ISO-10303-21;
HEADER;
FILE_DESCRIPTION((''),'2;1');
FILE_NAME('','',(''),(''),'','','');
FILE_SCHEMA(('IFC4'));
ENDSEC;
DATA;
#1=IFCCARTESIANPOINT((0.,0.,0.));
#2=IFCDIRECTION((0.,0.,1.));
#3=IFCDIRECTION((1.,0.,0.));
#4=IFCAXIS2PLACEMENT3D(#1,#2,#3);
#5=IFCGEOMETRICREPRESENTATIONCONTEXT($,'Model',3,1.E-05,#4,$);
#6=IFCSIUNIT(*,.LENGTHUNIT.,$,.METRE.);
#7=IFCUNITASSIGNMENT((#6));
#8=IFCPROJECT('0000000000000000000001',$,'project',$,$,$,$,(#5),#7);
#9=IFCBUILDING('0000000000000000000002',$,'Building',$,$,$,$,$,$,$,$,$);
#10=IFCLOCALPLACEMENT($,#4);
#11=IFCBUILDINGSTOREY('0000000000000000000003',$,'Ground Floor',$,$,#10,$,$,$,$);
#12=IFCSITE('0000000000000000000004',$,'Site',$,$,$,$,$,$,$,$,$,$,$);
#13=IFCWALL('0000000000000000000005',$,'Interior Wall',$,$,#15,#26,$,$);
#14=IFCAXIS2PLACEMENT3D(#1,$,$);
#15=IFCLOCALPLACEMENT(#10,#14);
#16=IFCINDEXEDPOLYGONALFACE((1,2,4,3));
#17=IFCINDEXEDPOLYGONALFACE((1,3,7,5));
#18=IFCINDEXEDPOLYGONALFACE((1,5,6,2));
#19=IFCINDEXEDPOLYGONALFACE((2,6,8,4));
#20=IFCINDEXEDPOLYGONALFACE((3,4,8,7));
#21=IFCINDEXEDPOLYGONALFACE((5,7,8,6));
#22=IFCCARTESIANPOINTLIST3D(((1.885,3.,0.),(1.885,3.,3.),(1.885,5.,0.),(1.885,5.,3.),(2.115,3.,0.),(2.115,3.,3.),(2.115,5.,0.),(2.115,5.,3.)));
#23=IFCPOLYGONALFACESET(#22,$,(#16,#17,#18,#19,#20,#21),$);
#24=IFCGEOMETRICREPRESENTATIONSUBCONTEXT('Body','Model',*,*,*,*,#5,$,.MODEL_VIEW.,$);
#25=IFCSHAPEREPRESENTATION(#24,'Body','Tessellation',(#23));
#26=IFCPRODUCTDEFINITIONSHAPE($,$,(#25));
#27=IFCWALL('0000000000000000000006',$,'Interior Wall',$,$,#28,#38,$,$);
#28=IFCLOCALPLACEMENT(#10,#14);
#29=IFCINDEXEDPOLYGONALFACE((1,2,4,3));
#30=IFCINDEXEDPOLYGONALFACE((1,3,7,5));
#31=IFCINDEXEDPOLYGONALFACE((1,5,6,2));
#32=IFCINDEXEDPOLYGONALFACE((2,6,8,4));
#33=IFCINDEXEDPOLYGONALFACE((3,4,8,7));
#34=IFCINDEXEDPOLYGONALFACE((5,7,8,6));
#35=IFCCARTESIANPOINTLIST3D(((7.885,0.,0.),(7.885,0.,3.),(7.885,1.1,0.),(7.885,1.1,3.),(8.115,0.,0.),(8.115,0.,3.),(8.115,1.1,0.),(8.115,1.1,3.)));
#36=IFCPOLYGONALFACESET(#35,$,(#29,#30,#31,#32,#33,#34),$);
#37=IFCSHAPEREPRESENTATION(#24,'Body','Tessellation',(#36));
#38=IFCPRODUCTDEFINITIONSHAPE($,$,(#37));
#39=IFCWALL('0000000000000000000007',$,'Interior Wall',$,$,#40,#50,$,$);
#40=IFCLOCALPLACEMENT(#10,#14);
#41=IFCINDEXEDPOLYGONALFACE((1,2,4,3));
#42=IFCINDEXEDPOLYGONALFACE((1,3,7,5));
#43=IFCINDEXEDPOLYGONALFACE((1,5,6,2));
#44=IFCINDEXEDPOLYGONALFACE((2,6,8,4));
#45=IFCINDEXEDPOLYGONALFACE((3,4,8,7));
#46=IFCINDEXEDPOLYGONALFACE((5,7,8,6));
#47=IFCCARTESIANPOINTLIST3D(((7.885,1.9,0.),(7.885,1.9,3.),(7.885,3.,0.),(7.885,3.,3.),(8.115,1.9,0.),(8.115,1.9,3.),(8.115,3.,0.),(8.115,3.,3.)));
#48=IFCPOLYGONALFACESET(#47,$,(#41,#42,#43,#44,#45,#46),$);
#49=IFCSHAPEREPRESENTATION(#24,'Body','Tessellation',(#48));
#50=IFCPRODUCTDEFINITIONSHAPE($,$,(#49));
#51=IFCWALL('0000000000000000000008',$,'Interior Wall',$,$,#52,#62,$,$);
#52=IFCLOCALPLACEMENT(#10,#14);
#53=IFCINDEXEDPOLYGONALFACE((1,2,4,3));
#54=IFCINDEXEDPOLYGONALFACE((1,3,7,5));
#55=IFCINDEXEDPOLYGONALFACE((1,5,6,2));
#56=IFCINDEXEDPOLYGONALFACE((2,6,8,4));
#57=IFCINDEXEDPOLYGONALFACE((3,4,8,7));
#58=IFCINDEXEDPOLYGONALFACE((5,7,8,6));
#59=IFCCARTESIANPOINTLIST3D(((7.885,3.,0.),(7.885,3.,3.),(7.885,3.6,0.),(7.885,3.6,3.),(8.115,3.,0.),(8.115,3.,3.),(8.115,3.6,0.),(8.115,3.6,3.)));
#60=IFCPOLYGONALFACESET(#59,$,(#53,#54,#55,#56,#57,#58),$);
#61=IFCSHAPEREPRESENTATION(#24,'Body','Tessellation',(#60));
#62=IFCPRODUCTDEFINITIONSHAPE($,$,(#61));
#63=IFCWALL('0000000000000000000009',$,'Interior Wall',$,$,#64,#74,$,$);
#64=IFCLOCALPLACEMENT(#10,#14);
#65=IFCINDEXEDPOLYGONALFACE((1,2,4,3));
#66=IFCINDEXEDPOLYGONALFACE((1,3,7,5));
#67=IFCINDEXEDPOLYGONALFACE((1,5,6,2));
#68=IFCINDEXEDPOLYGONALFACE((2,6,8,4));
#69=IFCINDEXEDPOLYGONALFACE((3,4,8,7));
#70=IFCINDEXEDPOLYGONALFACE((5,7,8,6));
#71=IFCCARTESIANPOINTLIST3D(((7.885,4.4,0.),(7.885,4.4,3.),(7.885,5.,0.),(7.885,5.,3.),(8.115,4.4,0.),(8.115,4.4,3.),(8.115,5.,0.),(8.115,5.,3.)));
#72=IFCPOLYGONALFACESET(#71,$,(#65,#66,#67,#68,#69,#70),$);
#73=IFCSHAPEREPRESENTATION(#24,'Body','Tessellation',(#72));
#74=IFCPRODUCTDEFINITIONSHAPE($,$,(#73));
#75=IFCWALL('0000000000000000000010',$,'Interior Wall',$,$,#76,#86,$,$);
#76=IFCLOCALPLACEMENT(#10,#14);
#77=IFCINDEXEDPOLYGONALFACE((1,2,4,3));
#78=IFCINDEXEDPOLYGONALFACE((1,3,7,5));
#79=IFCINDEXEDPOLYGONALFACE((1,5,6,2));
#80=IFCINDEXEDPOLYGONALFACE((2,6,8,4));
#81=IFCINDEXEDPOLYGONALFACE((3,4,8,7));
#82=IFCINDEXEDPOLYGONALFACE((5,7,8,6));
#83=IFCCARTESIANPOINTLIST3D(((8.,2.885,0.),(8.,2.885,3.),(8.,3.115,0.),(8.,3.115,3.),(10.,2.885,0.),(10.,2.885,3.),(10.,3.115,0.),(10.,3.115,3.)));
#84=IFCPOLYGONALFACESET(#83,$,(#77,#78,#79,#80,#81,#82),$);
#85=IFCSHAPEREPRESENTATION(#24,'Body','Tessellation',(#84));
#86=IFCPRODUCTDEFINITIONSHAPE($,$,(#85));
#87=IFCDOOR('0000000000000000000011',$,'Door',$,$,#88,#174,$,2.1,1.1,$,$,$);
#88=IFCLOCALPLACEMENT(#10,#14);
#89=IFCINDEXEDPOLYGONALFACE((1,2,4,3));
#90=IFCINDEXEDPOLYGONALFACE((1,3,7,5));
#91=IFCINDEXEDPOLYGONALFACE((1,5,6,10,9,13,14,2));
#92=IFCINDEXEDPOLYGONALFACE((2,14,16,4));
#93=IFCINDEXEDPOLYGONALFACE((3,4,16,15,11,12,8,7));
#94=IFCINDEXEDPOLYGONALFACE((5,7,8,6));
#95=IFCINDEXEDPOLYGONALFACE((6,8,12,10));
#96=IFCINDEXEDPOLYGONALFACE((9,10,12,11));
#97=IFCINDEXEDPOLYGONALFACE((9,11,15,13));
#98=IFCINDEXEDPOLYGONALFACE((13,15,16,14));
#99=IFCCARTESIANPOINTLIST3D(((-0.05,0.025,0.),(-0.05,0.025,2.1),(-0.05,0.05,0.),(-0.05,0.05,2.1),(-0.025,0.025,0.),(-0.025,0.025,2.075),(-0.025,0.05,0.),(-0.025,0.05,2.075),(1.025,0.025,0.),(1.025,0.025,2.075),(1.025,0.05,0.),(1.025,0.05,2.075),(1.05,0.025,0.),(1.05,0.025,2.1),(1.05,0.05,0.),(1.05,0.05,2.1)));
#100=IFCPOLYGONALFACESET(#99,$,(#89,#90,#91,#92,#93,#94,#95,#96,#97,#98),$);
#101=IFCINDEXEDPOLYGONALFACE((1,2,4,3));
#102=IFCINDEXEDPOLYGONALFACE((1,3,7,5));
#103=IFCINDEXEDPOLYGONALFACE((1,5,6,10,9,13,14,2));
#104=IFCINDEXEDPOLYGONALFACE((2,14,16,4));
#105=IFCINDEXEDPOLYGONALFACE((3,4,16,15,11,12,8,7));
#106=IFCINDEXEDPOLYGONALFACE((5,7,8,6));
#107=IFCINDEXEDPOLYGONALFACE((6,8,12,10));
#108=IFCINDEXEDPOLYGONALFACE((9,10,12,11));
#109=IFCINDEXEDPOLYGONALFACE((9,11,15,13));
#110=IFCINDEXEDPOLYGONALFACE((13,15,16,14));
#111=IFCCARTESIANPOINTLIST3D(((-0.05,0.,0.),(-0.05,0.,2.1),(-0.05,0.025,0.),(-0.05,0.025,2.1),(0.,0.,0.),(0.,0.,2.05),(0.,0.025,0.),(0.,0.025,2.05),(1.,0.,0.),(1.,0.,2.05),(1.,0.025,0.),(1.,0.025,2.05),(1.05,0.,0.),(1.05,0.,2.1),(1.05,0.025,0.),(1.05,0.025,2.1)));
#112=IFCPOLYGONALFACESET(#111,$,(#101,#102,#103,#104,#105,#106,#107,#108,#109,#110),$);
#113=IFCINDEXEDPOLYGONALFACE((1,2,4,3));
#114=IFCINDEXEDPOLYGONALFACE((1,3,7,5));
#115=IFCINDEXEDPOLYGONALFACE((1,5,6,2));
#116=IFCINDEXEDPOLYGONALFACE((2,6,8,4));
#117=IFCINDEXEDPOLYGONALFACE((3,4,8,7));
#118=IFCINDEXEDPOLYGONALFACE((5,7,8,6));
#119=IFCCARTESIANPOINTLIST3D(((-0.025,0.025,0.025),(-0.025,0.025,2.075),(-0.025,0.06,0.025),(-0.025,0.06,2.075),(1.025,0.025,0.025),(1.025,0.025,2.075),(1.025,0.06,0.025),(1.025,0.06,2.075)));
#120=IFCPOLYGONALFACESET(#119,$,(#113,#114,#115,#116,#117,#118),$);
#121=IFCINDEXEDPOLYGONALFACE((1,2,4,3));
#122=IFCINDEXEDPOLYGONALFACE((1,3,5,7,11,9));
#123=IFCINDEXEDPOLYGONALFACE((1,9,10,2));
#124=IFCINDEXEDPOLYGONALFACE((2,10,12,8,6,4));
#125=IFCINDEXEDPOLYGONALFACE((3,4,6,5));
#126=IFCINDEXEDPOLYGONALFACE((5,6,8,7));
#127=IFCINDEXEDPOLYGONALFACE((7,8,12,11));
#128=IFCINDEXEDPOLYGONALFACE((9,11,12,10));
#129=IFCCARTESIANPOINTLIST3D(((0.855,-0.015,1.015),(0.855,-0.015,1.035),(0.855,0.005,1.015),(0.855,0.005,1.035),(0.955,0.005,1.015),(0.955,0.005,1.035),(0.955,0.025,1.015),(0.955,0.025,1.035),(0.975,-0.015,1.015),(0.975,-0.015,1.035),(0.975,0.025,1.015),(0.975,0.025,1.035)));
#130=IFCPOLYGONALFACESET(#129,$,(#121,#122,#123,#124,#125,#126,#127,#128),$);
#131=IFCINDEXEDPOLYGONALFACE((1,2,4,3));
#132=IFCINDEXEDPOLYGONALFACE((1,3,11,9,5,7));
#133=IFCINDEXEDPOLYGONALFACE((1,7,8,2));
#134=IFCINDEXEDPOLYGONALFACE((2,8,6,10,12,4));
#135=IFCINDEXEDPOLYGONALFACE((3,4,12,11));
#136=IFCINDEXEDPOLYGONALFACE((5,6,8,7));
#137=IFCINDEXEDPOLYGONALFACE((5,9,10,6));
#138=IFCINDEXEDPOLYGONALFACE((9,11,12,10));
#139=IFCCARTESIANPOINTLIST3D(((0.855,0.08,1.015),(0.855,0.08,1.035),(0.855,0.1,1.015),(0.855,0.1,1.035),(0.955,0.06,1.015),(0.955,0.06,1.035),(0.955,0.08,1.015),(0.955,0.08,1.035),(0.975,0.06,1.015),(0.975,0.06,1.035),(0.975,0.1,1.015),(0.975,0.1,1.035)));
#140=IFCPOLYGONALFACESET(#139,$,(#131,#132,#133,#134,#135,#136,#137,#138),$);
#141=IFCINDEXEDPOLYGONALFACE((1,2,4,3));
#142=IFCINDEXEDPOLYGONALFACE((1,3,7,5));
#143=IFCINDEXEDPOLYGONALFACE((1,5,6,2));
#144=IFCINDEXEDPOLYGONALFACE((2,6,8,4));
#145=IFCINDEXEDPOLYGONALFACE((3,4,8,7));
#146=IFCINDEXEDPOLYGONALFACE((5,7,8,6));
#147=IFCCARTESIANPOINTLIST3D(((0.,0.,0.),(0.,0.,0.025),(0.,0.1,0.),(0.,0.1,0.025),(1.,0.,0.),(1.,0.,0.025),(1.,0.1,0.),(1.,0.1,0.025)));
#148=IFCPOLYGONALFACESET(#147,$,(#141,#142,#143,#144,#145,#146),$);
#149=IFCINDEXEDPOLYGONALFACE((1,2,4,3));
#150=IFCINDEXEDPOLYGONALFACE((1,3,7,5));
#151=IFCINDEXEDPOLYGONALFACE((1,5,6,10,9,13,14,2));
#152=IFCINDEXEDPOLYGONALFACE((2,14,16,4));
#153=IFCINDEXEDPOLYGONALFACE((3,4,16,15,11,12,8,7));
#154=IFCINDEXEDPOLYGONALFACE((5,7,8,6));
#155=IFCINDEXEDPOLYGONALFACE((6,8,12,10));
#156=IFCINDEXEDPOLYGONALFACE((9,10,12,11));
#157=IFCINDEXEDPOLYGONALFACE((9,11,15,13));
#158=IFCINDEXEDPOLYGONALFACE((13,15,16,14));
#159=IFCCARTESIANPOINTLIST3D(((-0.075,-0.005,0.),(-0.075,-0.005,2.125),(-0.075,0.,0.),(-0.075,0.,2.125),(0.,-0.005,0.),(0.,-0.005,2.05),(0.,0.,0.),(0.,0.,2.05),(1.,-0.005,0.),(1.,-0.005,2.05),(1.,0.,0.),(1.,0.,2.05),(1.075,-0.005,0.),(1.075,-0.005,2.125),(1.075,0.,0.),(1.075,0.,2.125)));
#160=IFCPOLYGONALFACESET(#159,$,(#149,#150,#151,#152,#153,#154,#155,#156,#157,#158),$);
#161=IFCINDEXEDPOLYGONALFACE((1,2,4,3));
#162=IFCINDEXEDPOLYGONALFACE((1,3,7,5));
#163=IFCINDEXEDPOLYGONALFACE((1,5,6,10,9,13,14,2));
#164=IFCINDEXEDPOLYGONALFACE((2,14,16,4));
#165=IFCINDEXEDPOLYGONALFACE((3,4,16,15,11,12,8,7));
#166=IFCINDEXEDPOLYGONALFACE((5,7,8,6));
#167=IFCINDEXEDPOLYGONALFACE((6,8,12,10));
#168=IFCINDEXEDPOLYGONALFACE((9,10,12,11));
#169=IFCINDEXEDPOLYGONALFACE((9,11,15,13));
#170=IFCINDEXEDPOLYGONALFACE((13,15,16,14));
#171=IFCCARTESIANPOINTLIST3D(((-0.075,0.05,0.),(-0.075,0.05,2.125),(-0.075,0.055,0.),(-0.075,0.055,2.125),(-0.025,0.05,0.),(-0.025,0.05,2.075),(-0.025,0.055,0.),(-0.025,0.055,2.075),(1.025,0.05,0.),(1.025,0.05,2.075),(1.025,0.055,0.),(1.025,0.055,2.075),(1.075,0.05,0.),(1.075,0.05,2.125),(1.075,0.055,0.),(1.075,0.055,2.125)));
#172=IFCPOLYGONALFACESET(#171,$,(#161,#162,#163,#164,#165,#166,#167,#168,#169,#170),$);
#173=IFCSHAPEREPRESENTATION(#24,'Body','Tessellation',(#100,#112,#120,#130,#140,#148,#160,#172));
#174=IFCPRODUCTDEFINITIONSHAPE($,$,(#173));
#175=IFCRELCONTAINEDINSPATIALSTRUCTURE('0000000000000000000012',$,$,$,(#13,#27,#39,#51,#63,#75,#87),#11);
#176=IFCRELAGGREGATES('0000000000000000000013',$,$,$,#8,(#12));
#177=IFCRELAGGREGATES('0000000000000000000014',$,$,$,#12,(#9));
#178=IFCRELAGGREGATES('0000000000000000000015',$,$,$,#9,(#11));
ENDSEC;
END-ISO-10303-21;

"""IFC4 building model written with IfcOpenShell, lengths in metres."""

from ifc_helpers import new_model, si_unit, frame, origin_with_axes, place, context, subcontext, project, spatial, line, indexed_curve, outline, extrude, element, save


model = new_model("IFC4")

# Units and contexts
model_context = context("Model", 3, precision=1e-05, world=origin_with_axes())
body_context = subcontext(model_context, "Body", "Model", "MODEL_VIEW")
ifc_project = project(units=[si_unit("LENGTHUNIT", "METRE")], contexts=[model_context])

# Site, building, storey
site = spatial("IfcSite", under=ifc_project, Name="Site")
building = spatial("IfcBuilding", under=site, Name="Building")
storey_placement = place(None, origin_with_axes())
storey = spatial("IfcBuildingStorey", under=building, at=storey_placement, Name="Ground Floor")

# Walls
wall_1_placement = place(storey_placement, frame((2.0, 5.0, 0.0), z_axis=(0.0, 0.0, 1.0), x_axis=(0.0, -1.0, 0.0)))
element("IfcWall", 1, at=wall_1_placement, inside=storey, Name="Interior Wall", context=body_context, shape_type="SweptSolid", body=[
    extrude(outline(indexed_curve([(0.0, 0.0), (0.0, 0.23), (2.0, 0.23), (2.0, 0.0), (0.0, 0.0)], self_intersect=False)), frame((0.0, -0.115, 0.0), z_axis=(0.0, 0.0, 1.0), x_axis=(1.0, 0.0, 0.0)), (0.0, 0.0, 1.0), 3.0),
])
for number, where, z_axis, x_axis, name in (
    (2, (8.0, 0.0, 0.0), (0.0, 0.0, 1.0), (0.0, 1.0, 0.0), "Interior Wall"),
    (3, (8.0, 1.9, 0.0), (0.0, 0.0, 1.0), (0.0, 1.0, 0.0), "Interior Wall"),
):
    element("IfcWall", number, at=place(storey_placement, frame(where, z_axis=z_axis, x_axis=x_axis)), inside=storey, Name=name, context=body_context, shape_type="SweptSolid", body=[
        extrude(outline(indexed_curve([(0.0, 0.0), (0.0, 0.23), (1.1, 0.23), (1.1, 0.0), (0.0, 0.0)], self_intersect=False)), frame((0.0, -0.115, 0.0), z_axis=(0.0, 0.0, 1.0), x_axis=(1.0, 0.0, 0.0)), (0.0, 0.0, 1.0), 3.0),
    ])
wall_2_placement = place(storey_placement, frame((8.0, 3.0, 0.0), z_axis=(0.0, 0.0, 1.0), x_axis=(0.0, 1.0, 0.0)))
element("IfcWall", 4, at=wall_2_placement, inside=storey, Name="Interior Wall", context=body_context, shape_type="SweptSolid", body=[
    extrude(outline(indexed_curve([(0.0, 0.0), (0.0, 0.23), (0.6, 0.23), (0.6, 0.0), (0.0, 0.0)], self_intersect=False)), frame((0.0, -0.115, 0.0), z_axis=(0.0, 0.0, 1.0), x_axis=(1.0, 0.0, 0.0)), (0.0, 0.0, 1.0), 3.0),
])
wall_3_placement = place(storey_placement, frame((8.0, 4.4, 0.0), z_axis=(0.0, 0.0, 1.0), x_axis=(0.0, 1.0, 0.0)))
element("IfcWall", 5, at=wall_3_placement, inside=storey, Name="Interior Wall", context=body_context, shape_type="SweptSolid", body=[
    extrude(outline(indexed_curve([(0.0, 0.0), (0.0, 0.23), (0.6, 0.23), (0.6, 0.0), (0.0, 0.0)], self_intersect=False)), frame((0.0, -0.115, 0.0), z_axis=(0.0, 0.0, 1.0), x_axis=(1.0, 0.0, 0.0)), (0.0, 0.0, 1.0), 3.0),
])
wall_4_placement = place(storey_placement, frame((10.0, 3.0, 0.0), z_axis=(0.0, 0.0, 1.0), x_axis=(-1.0, 0.0, 0.0)))
element("IfcWall", 6, at=wall_4_placement, inside=storey, Name="Interior Wall", context=body_context, shape_type="SweptSolid", body=[
    extrude(outline(indexed_curve([(0.0, 0.0), (0.0, 0.23), (2.0, 0.23), (2.0, 0.0), (0.0, 0.0)], self_intersect=False)), frame((0.0, -0.115, 0.0), z_axis=(0.0, 0.0, 1.0), x_axis=(1.0, 0.0, 0.0)), (0.0, 0.0, 1.0), 3.0),
])

# Door
door_1_placement = place(storey_placement, frame((-0.05, 0.0, 0.0), z_axis=(0.0, 0.0, 1.0), x_axis=(1.0, 0.0, 0.0)))
element("IfcDoor", 7, at=door_1_placement, inside=storey, Name="Door", OverallHeight=2.1, OverallWidth=1.1, context=body_context, shape_type="SweptSolid", body=[
    extrude(outline(indexed_curve([(0.0, 0.0), (0.0, 2.1), (1.1, 2.1), (1.1, 0.0), (1.075, 0.0), (1.075, 2.075), (0.025, 2.075), (0.025, 0.0)], segments=[line(1, 2, 3, 4, 5, 6, 7, 8, 1)])), frame((0.0, 0.025, 0.0), z_axis=(0.0, -1.0, 0.0), x_axis=(1.0, 0.0, 0.0)), (0.0, 0.0, -1.0), 0.025),
    extrude(outline(indexed_curve([(0.0, 0.0), (0.0, 2.1), (1.1, 2.1), (1.1, 0.0), (1.05, 0.0), (1.05, 2.05), (0.05, 2.05), (0.05, 0.0)], segments=[line(1, 2, 3, 4, 5, 6, 7, 8, 1)])), frame((0.0, 0.0, 0.0), z_axis=(0.0, -1.0, 0.0), x_axis=(1.0, 0.0, 0.0)), (0.0, 0.0, -1.0), 0.025),
    extrude(outline(indexed_curve([(0.0, 0.0), (1.05, 0.0), (1.05, 0.035), (0.0, 0.035)], segments=[line(1, 2, 3, 4, 1)])), frame((0.025, 0.025, 0.025), z_axis=(0.0, 0.0, 1.0), x_axis=(1.0, 0.0, 0.0)), (0.0, 0.0, 1.0), 2.05),
    extrude(outline(indexed_curve([(0.0, 0.0), (0.0, -0.04), (-0.12, -0.04), (-0.12, -0.02), (-0.02, -0.02), (-0.02, 0.0)], segments=[line(1, 2, 3, 4, 5, 6, 1)])), frame((1.025, 0.025, 1.015), z_axis=(0.0, 0.0, 1.0), x_axis=(1.0, 0.0, 0.0)), (0.0, 0.0, 1.0), 0.02),
    extrude(outline(indexed_curve([(0.0, 0.0), (0.0, 0.04), (-0.12, 0.04), (-0.12, 0.02), (-0.02, 0.02), (-0.02, 0.0)], segments=[line(1, 2, 3, 4, 5, 6, 1)])), frame((1.025, 0.06, 1.015), z_axis=(0.0, 0.0, 1.0), x_axis=(1.0, 0.0, 0.0)), (0.0, 0.0, 1.0), 0.02),
    extrude(outline(indexed_curve([(0.0, 0.0), (1.0, 0.0), (1.0, 0.1), (0.0, 0.1)], segments=[line(1, 2, 3, 4, 1)])), frame((0.05, 0.0, 0.0), z_axis=(0.0, 0.0, 1.0), x_axis=(1.0, 0.0, 0.0)), (0.0, 0.0, 1.0), 0.025),
    extrude(outline(indexed_curve([(0.0, 0.0), (0.0, 2.125), (1.15, 2.125), (1.15, 0.0), (1.075, 0.0), (1.075, 2.05), (0.075, 2.05), (0.075, 0.0)], segments=[line(1, 2, 3, 4, 5, 6, 7, 8, 1)])), frame((-0.025, -0.005, 0.0), z_axis=(0.0, -1.0, 0.0), x_axis=(1.0, 0.0, 0.0)), (0.0, 0.0, -1.0), 0.005),
    extrude(outline(indexed_curve([(0.0, 0.0), (0.0, 2.125), (1.15, 2.125), (1.15, 0.0), (1.1, 0.0), (1.1, 2.075), (0.05, 2.075), (0.05, 0.0)], segments=[line(1, 2, 3, 4, 5, 6, 7, 8, 1)])), frame((-0.025, 0.05, 0.0), z_axis=(0.0, -1.0, 0.0), x_axis=(1.0, 0.0, 0.0)), (0.0, 0.0, -1.0), 0.005),
])

save(model, "model.ifc")
